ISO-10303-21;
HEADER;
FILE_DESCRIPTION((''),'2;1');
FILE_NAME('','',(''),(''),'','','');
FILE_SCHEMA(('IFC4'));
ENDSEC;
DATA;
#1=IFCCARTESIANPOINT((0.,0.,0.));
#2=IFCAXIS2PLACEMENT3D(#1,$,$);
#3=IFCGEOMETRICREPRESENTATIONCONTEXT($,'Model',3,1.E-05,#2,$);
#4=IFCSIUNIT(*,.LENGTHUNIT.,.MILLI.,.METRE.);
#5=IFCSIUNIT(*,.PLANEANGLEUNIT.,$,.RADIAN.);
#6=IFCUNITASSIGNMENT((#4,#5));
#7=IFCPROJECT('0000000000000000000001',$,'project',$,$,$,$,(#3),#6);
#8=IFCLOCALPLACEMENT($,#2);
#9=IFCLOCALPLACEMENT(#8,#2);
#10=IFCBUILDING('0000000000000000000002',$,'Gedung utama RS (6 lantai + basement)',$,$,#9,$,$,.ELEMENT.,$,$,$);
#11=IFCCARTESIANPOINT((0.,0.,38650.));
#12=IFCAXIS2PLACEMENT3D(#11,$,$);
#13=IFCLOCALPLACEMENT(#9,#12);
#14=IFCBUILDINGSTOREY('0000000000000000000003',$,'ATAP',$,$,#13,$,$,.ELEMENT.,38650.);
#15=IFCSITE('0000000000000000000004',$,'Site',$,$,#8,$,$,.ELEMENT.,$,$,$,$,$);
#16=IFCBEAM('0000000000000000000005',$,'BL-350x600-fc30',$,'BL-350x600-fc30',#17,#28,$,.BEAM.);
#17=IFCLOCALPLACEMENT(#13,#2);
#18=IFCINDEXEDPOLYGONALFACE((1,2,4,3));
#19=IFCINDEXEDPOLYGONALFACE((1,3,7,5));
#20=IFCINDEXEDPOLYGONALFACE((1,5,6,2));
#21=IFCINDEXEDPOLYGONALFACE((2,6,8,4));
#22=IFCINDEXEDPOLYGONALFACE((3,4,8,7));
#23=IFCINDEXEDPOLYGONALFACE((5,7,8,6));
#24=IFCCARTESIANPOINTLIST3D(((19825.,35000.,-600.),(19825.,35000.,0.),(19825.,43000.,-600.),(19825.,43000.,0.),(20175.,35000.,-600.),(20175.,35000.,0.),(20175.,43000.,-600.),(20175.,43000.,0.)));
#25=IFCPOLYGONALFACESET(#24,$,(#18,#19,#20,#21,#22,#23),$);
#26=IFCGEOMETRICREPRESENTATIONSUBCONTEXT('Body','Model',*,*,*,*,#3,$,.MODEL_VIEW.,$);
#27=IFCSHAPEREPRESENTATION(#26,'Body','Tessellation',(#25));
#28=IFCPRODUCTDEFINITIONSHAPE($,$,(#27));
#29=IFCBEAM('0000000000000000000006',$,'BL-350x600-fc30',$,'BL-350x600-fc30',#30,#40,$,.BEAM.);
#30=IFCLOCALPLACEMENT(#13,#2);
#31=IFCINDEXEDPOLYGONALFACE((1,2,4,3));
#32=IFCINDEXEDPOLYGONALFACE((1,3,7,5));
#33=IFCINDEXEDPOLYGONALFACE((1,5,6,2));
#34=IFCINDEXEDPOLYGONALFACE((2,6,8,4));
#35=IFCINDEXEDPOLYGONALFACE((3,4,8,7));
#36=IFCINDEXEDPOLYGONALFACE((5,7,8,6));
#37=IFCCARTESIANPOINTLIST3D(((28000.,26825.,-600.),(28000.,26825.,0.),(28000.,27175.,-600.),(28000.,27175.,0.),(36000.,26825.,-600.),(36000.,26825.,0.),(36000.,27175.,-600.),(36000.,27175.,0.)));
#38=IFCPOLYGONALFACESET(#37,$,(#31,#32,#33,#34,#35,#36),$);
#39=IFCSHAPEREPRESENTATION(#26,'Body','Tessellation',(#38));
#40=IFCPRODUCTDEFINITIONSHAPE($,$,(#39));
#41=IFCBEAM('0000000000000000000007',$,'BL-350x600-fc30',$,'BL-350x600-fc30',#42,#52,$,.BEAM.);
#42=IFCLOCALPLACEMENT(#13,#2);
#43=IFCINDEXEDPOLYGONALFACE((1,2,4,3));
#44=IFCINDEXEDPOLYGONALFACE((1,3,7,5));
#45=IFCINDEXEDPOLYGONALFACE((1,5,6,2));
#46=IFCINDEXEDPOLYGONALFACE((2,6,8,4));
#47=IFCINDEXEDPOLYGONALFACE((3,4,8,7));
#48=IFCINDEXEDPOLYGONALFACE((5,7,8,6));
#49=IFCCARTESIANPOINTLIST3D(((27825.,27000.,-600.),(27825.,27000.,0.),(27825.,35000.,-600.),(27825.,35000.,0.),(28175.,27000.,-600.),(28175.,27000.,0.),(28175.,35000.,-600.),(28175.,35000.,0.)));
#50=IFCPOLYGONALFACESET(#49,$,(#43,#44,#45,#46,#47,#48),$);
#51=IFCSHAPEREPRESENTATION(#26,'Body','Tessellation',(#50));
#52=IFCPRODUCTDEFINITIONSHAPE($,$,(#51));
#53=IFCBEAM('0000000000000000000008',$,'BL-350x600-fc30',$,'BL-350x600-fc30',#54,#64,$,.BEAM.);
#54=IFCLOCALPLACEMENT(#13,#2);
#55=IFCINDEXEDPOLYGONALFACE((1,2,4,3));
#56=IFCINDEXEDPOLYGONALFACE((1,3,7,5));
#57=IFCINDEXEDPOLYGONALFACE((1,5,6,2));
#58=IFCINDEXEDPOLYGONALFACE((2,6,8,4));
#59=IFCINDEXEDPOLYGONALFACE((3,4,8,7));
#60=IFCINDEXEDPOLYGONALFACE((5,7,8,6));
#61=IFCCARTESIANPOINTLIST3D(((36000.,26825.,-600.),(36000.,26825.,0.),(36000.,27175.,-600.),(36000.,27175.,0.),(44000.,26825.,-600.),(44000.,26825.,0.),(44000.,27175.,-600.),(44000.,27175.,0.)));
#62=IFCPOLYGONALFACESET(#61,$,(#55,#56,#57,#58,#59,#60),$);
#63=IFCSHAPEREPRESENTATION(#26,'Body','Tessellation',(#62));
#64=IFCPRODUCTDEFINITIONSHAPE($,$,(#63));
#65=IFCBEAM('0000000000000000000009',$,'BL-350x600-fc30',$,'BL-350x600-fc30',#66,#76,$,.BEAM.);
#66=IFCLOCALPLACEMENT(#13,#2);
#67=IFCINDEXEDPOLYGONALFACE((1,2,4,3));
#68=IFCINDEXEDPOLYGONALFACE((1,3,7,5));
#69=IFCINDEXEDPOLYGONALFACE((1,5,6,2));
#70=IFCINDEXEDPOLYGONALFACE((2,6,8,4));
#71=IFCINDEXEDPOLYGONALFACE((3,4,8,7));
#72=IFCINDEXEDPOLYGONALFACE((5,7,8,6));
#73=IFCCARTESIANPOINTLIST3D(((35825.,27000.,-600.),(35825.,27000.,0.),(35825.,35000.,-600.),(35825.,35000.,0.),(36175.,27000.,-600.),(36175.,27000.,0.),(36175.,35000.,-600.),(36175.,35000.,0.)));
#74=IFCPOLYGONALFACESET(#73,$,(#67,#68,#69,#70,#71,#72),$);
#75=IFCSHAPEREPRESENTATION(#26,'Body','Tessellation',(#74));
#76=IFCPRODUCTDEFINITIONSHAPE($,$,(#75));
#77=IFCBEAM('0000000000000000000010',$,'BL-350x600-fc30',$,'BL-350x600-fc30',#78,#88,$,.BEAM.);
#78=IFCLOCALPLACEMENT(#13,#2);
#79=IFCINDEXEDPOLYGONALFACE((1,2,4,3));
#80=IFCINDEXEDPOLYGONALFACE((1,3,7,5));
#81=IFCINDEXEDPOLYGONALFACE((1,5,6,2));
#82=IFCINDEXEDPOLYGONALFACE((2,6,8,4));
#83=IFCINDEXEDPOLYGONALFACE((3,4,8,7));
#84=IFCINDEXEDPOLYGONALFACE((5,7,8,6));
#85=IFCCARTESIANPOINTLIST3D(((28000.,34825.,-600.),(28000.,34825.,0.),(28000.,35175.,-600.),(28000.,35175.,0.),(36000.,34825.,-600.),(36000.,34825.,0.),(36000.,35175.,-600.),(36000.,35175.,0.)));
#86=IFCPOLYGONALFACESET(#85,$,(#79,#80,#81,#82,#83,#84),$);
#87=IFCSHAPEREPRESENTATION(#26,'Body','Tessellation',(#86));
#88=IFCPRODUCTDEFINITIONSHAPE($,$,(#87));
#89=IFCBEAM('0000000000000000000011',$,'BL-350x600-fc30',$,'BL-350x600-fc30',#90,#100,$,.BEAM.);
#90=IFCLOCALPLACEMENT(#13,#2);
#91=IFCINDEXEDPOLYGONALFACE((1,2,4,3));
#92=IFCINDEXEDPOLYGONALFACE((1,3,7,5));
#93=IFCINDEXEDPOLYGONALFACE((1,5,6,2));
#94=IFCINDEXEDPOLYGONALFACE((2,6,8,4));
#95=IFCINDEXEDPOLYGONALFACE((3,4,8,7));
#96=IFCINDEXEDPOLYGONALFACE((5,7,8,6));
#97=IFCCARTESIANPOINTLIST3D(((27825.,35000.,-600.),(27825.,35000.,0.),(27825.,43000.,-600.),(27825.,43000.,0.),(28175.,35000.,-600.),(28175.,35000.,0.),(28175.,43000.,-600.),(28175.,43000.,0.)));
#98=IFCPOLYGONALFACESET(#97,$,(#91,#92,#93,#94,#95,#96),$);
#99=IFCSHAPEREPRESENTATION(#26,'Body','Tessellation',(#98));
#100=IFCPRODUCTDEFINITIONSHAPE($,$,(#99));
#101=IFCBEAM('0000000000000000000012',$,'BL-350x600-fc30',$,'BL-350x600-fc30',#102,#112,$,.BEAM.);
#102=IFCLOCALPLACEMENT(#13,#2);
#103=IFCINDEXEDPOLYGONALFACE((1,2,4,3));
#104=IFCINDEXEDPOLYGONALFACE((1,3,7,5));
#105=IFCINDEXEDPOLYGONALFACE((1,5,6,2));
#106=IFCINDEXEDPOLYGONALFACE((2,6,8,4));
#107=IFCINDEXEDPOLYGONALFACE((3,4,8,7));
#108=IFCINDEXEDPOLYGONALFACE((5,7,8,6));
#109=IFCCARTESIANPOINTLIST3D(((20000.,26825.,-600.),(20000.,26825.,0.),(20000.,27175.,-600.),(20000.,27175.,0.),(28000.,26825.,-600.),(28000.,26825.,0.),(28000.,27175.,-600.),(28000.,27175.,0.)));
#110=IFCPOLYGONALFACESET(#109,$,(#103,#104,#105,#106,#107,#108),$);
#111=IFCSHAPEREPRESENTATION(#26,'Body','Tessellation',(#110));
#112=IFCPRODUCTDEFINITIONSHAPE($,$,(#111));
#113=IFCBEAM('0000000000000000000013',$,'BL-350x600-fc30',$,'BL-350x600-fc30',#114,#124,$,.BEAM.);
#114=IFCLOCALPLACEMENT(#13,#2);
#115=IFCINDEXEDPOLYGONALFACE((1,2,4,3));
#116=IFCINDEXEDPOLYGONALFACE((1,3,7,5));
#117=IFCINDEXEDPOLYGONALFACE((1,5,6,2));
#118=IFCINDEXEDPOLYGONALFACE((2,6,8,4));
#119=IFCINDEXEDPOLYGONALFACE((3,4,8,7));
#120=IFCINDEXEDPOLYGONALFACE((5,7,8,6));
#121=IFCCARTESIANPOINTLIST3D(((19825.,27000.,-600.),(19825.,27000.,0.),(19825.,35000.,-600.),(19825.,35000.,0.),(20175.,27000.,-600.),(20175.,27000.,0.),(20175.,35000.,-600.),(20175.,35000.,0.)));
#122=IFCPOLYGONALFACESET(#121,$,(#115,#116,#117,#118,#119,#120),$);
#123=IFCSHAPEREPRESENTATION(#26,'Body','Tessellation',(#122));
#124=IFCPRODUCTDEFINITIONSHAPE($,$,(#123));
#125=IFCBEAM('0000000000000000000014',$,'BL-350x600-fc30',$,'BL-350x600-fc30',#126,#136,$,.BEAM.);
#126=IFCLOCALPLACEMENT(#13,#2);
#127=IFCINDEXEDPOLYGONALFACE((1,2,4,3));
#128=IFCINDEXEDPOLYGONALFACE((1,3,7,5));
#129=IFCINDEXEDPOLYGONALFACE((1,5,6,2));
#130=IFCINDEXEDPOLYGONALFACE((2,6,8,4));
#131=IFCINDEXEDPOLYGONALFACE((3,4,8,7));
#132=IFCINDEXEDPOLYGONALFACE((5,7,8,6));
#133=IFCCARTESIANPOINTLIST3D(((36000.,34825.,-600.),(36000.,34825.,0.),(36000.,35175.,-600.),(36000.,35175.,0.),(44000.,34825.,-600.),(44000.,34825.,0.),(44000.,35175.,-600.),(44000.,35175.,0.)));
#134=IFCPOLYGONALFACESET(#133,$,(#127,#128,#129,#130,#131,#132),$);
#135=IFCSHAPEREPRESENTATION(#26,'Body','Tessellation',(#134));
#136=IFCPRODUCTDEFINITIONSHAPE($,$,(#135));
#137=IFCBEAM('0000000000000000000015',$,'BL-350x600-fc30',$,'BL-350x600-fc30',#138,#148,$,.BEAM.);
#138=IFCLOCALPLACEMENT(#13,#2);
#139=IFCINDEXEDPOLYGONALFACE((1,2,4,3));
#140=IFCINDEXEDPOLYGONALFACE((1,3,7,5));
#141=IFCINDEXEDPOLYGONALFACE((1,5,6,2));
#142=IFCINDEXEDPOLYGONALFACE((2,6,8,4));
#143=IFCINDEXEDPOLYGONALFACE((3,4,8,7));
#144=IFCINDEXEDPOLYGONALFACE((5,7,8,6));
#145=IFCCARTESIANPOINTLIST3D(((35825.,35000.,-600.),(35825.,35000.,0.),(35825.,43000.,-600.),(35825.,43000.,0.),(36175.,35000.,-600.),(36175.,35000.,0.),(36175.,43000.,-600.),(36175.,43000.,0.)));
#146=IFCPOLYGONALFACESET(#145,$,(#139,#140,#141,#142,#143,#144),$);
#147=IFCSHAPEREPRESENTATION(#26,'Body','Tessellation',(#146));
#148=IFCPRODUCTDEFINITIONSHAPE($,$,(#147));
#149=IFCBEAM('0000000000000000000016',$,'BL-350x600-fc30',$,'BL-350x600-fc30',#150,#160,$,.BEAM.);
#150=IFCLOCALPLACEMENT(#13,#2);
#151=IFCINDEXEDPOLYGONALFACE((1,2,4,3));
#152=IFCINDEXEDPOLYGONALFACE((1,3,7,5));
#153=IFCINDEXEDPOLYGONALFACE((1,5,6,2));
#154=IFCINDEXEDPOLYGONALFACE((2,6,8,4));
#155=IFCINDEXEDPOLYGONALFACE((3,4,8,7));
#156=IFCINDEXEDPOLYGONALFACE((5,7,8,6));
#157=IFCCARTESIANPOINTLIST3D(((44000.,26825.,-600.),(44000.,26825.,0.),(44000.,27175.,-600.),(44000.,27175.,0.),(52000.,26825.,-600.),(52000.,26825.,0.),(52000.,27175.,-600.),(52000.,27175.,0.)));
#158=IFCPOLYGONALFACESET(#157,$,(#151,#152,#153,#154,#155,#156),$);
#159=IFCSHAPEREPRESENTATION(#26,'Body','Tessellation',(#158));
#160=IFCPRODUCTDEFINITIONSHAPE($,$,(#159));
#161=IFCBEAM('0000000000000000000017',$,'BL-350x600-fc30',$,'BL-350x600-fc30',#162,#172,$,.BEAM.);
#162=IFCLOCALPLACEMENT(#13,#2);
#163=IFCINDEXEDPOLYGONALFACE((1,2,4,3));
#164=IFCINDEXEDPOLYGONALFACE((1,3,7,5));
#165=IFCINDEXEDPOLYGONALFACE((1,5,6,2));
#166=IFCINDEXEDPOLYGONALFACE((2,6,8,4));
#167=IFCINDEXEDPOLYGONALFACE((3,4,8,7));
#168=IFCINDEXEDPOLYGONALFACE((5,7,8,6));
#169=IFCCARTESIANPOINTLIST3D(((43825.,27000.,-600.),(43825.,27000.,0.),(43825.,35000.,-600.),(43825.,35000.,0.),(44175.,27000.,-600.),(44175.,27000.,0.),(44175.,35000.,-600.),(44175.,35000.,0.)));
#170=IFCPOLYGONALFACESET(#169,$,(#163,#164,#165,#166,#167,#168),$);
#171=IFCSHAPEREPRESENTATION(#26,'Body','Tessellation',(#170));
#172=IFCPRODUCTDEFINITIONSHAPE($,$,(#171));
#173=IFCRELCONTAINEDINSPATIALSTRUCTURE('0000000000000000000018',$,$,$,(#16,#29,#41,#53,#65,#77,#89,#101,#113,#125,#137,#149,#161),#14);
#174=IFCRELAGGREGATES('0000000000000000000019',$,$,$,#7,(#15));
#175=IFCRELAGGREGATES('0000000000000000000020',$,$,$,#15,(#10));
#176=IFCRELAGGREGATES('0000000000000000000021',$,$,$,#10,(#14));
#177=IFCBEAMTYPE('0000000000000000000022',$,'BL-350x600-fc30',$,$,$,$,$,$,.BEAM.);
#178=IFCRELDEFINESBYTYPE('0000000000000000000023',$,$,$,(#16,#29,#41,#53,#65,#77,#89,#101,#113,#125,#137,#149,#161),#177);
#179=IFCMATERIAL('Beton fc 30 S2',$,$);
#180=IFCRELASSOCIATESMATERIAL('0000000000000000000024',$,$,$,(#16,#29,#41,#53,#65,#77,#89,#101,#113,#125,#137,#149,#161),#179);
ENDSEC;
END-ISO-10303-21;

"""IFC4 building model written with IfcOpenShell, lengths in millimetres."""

from ifc_helpers import new_model, si_unit, frame, origin, origin_2d, place, context, subcontext, project, spatial, rectangle, extrude, material, material_profile, profile_set, profile_usage, type_object, element, save


model = new_model("IFC4")

# Units and contexts
model_context = context("Model", 3, precision=1e-05, world=origin())
body_context = subcontext(model_context, "Body", "Model", "MODEL_VIEW")
ifc_project = project(units=[si_unit("LENGTHUNIT", "METRE", prefix="MILLI"), si_unit("PLANEANGLEUNIT", "RADIAN")], contexts=[model_context])

# Site, building, storey
site_placement = place(None, origin())
site = spatial("IfcSite", under=ifc_project, at=site_placement, Name="Site", CompositionType="ELEMENT")
building_placement = place(site_placement, origin())
building = spatial("IfcBuilding", under=site, at=building_placement, Name="Gedung utama RS (6 lantai + basement)", CompositionType="ELEMENT")
storey_placement = place(building_placement, frame((0.0, 0.0, 38650.0)))
storey = spatial("IfcBuildingStorey", under=building, at=storey_placement, Name="ATAP", CompositionType="ELEMENT", Elevation=38650.0)

# Beams
ifc_material_1 = material(Name="Beton fc 30 S2")
ifc_material_profile_1 = material_profile(ifc_material_1, rectangle(XDim=350.0, YDim=600.0, at=origin_2d()), Name="BL-350x600-fc30")
ifc_profile_set_1 = profile_set([ifc_material_profile_1], Name="BL-350x600-fc30")
ifc_profile_usage_1 = profile_usage(ifc_profile_set_1, cardinal=8)
beam_type = type_object("IfcBeamType", Name="BL-350x600-fc30", PredefinedType="BEAM")
beam_1_placement = place(storey_placement, frame((20000.0, 35000.0, -300.0)))
element("IfcBeam", 1, at=beam_1_placement, inside=storey, type_object=beam_type, material=ifc_profile_usage_1, Name="BL-350x600-fc30", ObjectType="BL-350x600-fc30", PredefinedType="BEAM", context=body_context, shape_type="SweptSolid", body=[
    extrude(rectangle(XDim=350.0, YDim=600.0, at=origin_2d()), frame((0.0, 0.0, 0.0), z_axis=(0.0, 1.0, 0.0), x_axis=(-1.0, 0.0, 0.0)), (0.0, 0.0, 1.0), 8000.0),
])
beam_2_placement = place(storey_placement, frame((28000.0, 27000.0, -300.0)))
element("IfcBeam", 2, at=beam_2_placement, inside=storey, type_object=beam_type, material=ifc_profile_usage_1, Name="BL-350x600-fc30", ObjectType="BL-350x600-fc30", PredefinedType="BEAM", context=body_context, shape_type="SweptSolid", body=[
    extrude(rectangle(XDim=350.0, YDim=600.0, at=origin_2d()), frame((0.0, 0.0, 0.0), z_axis=(1.0, 0.0, 0.0), x_axis=(0.0, 1.0, 0.0)), (0.0, 0.0, 1.0), 8000.0),
])
beam_3_placement = place(storey_placement, frame((28000.0, 27000.0, -300.0)))
element("IfcBeam", 3, at=beam_3_placement, inside=storey, type_object=beam_type, material=ifc_profile_usage_1, Name="BL-350x600-fc30", ObjectType="BL-350x600-fc30", PredefinedType="BEAM", context=body_context, shape_type="SweptSolid", body=[
    extrude(rectangle(XDim=350.0, YDim=600.0, at=origin_2d()), frame((0.0, 0.0, 0.0), z_axis=(0.0, 1.0, 0.0), x_axis=(-1.0, 0.0, 0.0)), (0.0, 0.0, 1.0), 8000.0),
])
beam_4_placement = place(storey_placement, frame((36000.0, 27000.0, -300.0)))
element("IfcBeam", 4, at=beam_4_placement, inside=storey, type_object=beam_type, material=ifc_profile_usage_1, Name="BL-350x600-fc30", ObjectType="BL-350x600-fc30", PredefinedType="BEAM", context=body_context, shape_type="SweptSolid", body=[
    extrude(rectangle(XDim=350.0, YDim=600.0, at=origin_2d()), frame((0.0, 0.0, 0.0), z_axis=(1.0, 0.0, 0.0), x_axis=(0.0, 1.0, 0.0)), (0.0, 0.0, 1.0), 8000.0),
])
beam_5_placement = place(storey_placement, frame((36000.0, 27000.0, -300.0)))
element("IfcBeam", 5, at=beam_5_placement, inside=storey, type_object=beam_type, material=ifc_profile_usage_1, Name="BL-350x600-fc30", ObjectType="BL-350x600-fc30", PredefinedType="BEAM", context=body_context, shape_type="SweptSolid", body=[
    extrude(rectangle(XDim=350.0, YDim=600.0, at=origin_2d()), frame((0.0, 0.0, 0.0), z_axis=(0.0, 1.0, 0.0), x_axis=(-1.0, 0.0, 0.0)), (0.0, 0.0, 1.0), 8000.0),
])
beam_6_placement = place(storey_placement, frame((28000.0, 35000.0, -300.0)))
element("IfcBeam", 6, at=beam_6_placement, inside=storey, type_object=beam_type, material=ifc_profile_usage_1, Name="BL-350x600-fc30", ObjectType="BL-350x600-fc30", PredefinedType="BEAM", context=body_context, shape_type="SweptSolid", body=[
    extrude(rectangle(XDim=350.0, YDim=600.0, at=origin_2d()), frame((0.0, 0.0, 0.0), z_axis=(1.0, 0.0, 0.0), x_axis=(0.0, 1.0, 0.0)), (0.0, 0.0, 1.0), 8000.0),
])
beam_7_placement = place(storey_placement, frame((28000.0, 35000.0, -300.0)))
element("IfcBeam", 7, at=beam_7_placement, inside=storey, type_object=beam_type, material=ifc_profile_usage_1, Name="BL-350x600-fc30", ObjectType="BL-350x600-fc30", PredefinedType="BEAM", context=body_context, shape_type="SweptSolid", body=[
    extrude(rectangle(XDim=350.0, YDim=600.0, at=origin_2d()), frame((0.0, 0.0, 0.0), z_axis=(0.0, 1.0, 0.0), x_axis=(-1.0, 0.0, 0.0)), (0.0, 0.0, 1.0), 8000.0),
])
beam_8_placement = place(storey_placement, frame((20000.0, 27000.0, -300.0)))
element("IfcBeam", 8, at=beam_8_placement, inside=storey, type_object=beam_type, material=ifc_profile_usage_1, Name="BL-350x600-fc30", ObjectType="BL-350x600-fc30", PredefinedType="BEAM", context=body_context, shape_type="SweptSolid", body=[
    extrude(rectangle(XDim=350.0, YDim=600.0, at=origin_2d()), frame((0.0, 0.0, 0.0), z_axis=(1.0, 0.0, 0.0), x_axis=(0.0, 1.0, 0.0)), (0.0, 0.0, 1.0), 8000.0),
])
beam_9_placement = place(storey_placement, frame((20000.0, 27000.0, -300.0)))
element("IfcBeam", 9, at=beam_9_placement, inside=storey, type_object=beam_type, material=ifc_profile_usage_1, Name="BL-350x600-fc30", ObjectType="BL-350x600-fc30", PredefinedType="BEAM", context=body_context, shape_type="SweptSolid", body=[
    extrude(rectangle(XDim=350.0, YDim=600.0, at=origin_2d()), frame((0.0, 0.0, 0.0), z_axis=(0.0, 1.0, 0.0), x_axis=(-1.0, 0.0, 0.0)), (0.0, 0.0, 1.0), 8000.0),
])
beam_10_placement = place(storey_placement, frame((36000.0, 35000.0, -300.0)))
element("IfcBeam", 10, at=beam_10_placement, inside=storey, type_object=beam_type, material=ifc_profile_usage_1, Name="BL-350x600-fc30", ObjectType="BL-350x600-fc30", PredefinedType="BEAM", context=body_context, shape_type="SweptSolid", body=[
    extrude(rectangle(XDim=350.0, YDim=600.0, at=origin_2d()), frame((0.0, 0.0, 0.0), z_axis=(1.0, 0.0, 0.0), x_axis=(0.0, 1.0, 0.0)), (0.0, 0.0, 1.0), 8000.0),
])
beam_11_placement = place(storey_placement, frame((36000.0, 35000.0, -300.0)))
element("IfcBeam", 11, at=beam_11_placement, inside=storey, type_object=beam_type, material=ifc_profile_usage_1, Name="BL-350x600-fc30", ObjectType="BL-350x600-fc30", PredefinedType="BEAM", context=body_context, shape_type="SweptSolid", body=[
    extrude(rectangle(XDim=350.0, YDim=600.0, at=origin_2d()), frame((0.0, 0.0, 0.0), z_axis=(0.0, 1.0, 0.0), x_axis=(-1.0, 0.0, 0.0)), (0.0, 0.0, 1.0), 8000.0),
])
beam_12_placement = place(storey_placement, frame((44000.0, 27000.0, -300.0)))
element("IfcBeam", 12, at=beam_12_placement, inside=storey, type_object=beam_type, material=ifc_profile_usage_1, Name="BL-350x600-fc30", ObjectType="BL-350x600-fc30", PredefinedType="BEAM", context=body_context, shape_type="SweptSolid", body=[
    extrude(rectangle(XDim=350.0, YDim=600.0, at=origin_2d()), frame((0.0, 0.0, 0.0), z_axis=(1.0, 0.0, 0.0), x_axis=(0.0, 1.0, 0.0)), (0.0, 0.0, 1.0), 8000.0),
])
beam_13_placement = place(storey_placement, frame((44000.0, 27000.0, -300.0)))
element("IfcBeam", 13, at=beam_13_placement, inside=storey, type_object=beam_type, material=ifc_profile_usage_1, Name="BL-350x600-fc30", ObjectType="BL-350x600-fc30", PredefinedType="BEAM", context=body_context, shape_type="SweptSolid", body=[
    extrude(rectangle(XDim=350.0, YDim=600.0, at=origin_2d()), frame((0.0, 0.0, 0.0), z_axis=(0.0, 1.0, 0.0), x_axis=(-1.0, 0.0, 0.0)), (0.0, 0.0, 1.0), 8000.0),
])

save(model, "model.ifc")
